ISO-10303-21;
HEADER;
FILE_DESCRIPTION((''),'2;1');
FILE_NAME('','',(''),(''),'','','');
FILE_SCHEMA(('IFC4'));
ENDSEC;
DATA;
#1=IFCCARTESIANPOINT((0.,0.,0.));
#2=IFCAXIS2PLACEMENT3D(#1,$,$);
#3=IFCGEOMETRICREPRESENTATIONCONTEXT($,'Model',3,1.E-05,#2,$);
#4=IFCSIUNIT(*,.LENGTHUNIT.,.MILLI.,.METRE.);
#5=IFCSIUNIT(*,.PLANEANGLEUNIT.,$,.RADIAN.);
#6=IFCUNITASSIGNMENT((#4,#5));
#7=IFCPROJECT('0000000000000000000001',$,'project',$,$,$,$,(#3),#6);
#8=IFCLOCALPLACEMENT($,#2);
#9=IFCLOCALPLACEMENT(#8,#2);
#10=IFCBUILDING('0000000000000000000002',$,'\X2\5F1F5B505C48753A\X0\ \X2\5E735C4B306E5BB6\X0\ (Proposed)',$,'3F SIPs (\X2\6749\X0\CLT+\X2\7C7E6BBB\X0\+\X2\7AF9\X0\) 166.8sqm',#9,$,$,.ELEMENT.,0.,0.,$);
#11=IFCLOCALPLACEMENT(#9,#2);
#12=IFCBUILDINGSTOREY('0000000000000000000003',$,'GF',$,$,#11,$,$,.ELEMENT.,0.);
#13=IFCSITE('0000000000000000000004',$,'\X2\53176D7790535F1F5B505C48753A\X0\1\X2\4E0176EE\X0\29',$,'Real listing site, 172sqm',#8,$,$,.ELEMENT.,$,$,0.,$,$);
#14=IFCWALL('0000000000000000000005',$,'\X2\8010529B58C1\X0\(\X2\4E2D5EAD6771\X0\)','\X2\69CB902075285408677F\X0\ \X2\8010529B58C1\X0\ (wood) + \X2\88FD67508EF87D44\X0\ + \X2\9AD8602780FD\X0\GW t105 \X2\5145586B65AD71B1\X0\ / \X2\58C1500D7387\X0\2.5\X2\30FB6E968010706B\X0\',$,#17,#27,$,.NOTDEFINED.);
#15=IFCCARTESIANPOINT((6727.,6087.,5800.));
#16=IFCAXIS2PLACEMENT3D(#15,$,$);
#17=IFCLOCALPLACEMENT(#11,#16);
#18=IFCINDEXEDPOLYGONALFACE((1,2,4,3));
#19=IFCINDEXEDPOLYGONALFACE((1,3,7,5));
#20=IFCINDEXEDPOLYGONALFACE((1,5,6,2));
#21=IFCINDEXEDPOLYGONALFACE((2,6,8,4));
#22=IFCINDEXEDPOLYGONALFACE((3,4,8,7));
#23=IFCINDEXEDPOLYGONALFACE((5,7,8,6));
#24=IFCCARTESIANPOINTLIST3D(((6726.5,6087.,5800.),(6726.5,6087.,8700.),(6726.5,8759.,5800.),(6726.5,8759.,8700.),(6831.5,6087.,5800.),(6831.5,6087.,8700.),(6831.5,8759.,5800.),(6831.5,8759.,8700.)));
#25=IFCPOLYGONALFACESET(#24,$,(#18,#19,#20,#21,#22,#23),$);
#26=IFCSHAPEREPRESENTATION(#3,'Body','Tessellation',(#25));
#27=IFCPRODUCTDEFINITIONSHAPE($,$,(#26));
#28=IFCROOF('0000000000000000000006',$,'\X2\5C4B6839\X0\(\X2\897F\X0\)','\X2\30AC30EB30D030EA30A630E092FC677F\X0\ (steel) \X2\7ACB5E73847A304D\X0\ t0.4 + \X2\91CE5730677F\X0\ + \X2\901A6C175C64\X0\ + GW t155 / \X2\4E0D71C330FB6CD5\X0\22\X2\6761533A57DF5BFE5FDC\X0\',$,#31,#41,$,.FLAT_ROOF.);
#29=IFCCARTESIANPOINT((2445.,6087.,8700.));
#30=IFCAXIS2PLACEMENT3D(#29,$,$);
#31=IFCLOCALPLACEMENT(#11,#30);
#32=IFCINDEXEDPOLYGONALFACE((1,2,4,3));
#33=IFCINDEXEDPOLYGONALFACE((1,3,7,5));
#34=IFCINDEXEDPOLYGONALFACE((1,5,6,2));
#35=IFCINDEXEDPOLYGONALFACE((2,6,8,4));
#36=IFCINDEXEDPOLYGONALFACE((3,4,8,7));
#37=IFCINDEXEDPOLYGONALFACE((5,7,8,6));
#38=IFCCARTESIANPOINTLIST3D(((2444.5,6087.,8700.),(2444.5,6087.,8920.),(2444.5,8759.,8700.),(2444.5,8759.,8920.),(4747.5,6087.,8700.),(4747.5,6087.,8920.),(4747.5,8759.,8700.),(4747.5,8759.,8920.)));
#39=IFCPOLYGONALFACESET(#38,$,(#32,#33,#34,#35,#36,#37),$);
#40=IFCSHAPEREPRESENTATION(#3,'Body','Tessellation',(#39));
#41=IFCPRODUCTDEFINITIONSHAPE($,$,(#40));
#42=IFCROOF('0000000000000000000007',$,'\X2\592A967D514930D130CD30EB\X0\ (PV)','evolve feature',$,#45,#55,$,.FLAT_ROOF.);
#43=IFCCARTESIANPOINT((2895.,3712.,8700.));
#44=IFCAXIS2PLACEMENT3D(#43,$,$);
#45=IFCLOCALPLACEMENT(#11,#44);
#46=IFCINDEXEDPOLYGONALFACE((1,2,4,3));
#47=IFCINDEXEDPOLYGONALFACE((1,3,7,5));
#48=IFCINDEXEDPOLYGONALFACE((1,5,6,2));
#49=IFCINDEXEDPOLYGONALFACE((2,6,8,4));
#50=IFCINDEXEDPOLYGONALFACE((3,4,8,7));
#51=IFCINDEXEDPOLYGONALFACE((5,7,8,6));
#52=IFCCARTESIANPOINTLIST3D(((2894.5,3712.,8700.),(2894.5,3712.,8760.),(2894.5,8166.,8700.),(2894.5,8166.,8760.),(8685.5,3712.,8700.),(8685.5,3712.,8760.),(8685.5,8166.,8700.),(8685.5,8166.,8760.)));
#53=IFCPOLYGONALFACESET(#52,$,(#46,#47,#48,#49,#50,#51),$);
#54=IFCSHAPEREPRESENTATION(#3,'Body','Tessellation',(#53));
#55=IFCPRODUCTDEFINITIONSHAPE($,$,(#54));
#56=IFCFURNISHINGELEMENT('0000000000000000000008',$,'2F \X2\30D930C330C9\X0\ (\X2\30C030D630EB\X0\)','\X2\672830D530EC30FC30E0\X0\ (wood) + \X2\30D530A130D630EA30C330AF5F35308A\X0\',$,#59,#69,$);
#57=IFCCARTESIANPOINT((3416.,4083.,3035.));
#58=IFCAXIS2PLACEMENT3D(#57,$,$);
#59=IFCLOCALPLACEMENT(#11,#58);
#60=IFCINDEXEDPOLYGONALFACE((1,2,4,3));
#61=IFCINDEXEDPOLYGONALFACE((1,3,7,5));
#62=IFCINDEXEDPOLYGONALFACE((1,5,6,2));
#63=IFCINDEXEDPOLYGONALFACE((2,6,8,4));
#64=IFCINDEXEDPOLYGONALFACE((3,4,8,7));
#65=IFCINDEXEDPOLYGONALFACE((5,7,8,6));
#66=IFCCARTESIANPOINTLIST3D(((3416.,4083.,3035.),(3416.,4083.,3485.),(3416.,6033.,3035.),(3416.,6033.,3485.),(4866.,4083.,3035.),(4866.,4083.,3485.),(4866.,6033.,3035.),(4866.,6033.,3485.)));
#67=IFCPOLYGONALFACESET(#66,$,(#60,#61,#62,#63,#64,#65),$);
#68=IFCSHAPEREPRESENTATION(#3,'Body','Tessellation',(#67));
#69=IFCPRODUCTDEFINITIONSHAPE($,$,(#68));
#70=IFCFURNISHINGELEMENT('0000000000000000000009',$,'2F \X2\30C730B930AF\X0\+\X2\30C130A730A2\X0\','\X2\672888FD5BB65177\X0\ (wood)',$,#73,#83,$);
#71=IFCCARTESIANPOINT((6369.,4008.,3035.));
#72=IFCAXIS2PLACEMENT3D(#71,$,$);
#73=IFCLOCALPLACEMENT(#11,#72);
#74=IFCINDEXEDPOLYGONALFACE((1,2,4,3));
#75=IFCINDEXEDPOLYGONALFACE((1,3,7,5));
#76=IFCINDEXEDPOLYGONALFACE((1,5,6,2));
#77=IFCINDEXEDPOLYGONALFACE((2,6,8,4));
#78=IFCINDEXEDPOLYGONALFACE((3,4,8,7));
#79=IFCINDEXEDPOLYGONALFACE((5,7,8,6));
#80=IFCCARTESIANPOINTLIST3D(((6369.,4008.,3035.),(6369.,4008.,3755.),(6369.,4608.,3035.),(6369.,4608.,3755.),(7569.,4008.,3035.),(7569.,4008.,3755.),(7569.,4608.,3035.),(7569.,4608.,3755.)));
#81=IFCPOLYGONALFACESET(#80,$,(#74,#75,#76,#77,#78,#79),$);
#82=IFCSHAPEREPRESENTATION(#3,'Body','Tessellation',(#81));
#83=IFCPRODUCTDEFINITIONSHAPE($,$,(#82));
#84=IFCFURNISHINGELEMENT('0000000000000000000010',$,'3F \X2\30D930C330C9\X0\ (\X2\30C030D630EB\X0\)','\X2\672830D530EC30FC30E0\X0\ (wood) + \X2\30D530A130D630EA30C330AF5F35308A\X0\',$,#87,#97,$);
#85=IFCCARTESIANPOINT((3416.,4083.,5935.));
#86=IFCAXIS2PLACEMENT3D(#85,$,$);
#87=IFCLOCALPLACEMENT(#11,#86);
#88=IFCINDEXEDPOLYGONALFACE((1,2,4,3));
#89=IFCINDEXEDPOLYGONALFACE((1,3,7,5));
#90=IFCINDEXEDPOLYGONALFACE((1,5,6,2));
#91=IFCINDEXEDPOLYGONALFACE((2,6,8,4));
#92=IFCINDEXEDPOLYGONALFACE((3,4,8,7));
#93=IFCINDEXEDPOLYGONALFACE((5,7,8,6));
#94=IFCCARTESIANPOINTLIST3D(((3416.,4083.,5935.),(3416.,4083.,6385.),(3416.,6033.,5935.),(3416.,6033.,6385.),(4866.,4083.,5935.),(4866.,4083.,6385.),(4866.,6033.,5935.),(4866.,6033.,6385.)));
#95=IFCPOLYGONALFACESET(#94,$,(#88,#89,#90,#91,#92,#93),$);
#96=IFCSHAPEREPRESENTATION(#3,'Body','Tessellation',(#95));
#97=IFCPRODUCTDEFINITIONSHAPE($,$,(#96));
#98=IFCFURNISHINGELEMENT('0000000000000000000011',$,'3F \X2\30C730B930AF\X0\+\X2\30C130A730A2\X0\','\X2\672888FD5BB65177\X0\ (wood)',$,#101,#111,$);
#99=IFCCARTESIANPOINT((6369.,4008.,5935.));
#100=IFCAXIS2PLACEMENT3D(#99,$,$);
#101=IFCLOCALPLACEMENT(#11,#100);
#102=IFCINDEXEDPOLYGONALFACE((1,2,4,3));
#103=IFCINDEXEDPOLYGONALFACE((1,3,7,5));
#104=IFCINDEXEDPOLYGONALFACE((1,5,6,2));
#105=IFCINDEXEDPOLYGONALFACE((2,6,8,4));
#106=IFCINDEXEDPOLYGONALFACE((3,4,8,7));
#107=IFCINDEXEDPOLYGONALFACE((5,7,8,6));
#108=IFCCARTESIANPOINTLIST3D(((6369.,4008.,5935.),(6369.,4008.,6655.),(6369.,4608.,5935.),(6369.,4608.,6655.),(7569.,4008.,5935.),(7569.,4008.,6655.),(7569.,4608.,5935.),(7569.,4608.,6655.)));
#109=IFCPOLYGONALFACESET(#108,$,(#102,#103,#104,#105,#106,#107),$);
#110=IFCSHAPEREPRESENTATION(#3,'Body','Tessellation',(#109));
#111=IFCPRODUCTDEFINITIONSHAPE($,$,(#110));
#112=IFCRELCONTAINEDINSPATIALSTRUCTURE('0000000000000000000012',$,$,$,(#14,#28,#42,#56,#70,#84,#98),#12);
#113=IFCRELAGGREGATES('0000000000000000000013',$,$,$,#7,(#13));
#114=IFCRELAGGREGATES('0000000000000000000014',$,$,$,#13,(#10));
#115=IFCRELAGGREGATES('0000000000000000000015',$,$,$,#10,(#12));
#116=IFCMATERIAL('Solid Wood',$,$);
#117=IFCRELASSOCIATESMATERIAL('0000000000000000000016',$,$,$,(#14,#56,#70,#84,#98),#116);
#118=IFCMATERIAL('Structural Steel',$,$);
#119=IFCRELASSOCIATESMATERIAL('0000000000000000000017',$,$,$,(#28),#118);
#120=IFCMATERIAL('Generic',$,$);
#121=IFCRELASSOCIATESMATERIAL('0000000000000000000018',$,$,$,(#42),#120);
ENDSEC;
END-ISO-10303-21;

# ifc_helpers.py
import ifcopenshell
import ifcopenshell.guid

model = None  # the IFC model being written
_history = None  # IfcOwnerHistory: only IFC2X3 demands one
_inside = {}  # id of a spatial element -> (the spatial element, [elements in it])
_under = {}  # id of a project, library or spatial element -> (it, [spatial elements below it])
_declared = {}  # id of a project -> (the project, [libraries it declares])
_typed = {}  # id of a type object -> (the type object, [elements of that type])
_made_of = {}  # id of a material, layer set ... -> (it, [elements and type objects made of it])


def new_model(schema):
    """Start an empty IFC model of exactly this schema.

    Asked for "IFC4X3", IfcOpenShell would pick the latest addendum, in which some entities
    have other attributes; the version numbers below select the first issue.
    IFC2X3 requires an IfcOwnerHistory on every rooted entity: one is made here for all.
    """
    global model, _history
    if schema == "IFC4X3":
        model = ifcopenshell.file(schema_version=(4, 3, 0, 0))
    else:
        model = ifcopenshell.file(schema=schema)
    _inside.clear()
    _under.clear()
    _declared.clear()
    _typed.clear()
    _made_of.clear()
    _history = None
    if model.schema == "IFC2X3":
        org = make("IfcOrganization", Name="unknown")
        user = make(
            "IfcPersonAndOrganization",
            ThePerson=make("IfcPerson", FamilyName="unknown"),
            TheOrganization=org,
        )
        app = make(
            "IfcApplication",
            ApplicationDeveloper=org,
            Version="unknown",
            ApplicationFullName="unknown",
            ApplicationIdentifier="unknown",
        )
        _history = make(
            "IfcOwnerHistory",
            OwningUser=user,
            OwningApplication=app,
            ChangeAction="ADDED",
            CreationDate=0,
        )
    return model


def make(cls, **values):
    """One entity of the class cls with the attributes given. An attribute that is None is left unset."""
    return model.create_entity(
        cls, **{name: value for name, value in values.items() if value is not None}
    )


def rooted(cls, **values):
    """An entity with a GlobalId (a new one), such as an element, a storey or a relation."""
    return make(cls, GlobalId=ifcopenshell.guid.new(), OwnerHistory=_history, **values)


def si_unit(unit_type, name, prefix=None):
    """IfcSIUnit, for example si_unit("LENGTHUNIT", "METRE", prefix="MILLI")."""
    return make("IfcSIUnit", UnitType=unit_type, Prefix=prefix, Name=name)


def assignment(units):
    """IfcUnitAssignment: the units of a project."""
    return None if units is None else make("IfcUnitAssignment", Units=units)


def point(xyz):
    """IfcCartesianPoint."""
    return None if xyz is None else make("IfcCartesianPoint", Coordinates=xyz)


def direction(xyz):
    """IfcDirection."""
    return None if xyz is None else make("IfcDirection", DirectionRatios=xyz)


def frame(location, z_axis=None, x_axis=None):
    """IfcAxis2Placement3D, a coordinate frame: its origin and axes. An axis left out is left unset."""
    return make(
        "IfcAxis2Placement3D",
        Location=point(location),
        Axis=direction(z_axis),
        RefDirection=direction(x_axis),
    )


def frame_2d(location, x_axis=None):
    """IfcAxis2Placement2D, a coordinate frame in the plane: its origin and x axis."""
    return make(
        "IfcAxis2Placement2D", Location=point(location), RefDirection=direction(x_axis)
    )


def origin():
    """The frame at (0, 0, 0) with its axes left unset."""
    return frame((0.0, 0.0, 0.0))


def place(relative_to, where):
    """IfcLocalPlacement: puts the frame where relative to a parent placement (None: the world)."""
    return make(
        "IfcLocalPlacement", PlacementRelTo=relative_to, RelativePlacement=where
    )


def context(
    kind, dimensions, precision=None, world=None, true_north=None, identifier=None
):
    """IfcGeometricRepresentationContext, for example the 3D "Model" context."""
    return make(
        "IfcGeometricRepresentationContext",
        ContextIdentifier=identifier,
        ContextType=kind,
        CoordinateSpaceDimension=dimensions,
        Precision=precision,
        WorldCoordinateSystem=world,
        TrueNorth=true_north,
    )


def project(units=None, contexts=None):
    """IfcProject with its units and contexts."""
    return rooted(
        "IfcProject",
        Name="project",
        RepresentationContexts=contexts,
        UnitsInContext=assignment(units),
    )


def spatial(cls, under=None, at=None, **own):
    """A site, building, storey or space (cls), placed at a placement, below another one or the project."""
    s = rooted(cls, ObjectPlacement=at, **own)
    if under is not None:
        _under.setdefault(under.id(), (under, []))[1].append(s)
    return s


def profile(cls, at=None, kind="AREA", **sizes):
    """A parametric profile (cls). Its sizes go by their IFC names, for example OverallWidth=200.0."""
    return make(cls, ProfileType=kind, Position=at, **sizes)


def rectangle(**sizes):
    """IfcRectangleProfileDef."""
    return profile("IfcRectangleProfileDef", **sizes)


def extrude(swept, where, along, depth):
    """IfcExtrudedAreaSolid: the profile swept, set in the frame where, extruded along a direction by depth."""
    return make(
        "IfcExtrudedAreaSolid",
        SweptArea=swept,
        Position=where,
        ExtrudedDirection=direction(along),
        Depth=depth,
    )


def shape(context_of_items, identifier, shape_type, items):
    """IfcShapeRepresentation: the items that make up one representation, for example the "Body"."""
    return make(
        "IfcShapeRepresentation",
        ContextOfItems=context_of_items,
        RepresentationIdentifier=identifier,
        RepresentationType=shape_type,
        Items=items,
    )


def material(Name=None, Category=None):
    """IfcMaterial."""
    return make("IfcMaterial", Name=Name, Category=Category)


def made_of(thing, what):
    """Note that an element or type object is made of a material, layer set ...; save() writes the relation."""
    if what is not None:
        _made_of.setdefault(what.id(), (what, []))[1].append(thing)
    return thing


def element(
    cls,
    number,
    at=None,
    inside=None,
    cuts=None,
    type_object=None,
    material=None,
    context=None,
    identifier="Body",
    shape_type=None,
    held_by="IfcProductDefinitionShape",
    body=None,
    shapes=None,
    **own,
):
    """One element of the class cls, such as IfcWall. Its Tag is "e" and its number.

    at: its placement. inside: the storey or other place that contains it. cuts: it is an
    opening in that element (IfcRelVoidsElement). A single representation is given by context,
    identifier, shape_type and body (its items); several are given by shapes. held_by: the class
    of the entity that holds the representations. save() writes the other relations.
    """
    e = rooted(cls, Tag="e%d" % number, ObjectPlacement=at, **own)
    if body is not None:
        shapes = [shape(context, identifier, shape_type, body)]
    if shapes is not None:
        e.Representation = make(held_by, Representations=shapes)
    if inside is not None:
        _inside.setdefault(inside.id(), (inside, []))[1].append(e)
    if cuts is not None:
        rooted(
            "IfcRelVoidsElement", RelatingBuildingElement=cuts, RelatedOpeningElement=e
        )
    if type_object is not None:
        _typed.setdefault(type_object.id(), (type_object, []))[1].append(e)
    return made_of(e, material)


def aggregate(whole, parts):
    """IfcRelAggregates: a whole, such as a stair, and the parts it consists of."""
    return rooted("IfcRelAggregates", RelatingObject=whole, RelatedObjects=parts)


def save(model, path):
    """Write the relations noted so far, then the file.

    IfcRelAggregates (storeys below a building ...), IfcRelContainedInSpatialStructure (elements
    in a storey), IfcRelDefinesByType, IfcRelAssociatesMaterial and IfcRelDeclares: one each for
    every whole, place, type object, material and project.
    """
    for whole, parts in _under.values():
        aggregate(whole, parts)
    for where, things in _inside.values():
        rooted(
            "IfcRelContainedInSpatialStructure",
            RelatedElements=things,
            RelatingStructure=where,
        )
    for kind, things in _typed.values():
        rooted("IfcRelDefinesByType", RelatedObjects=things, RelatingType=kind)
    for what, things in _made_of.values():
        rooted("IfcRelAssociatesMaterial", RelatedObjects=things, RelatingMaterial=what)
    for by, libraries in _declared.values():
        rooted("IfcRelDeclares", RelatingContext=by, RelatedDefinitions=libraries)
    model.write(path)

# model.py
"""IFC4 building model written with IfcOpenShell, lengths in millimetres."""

from ifc_helpers import new_model, si_unit, frame, frame_2d, origin, place, context, project, spatial, rectangle, extrude, material, element, save


model = new_model("IFC4")

# Units and contexts
model_context = context("Model", 3, precision=1e-05, world=origin())
ifc_project = project(units=[si_unit("LENGTHUNIT", "METRE", prefix="MILLI"), si_unit("PLANEANGLEUNIT", "RADIAN")], contexts=[model_context])

# Site, building, storey
site_placement = place(None, origin())
site = spatial("IfcSite", under=ifc_project, at=site_placement, Name="北海道弟子屈町1丁目29", ObjectType="Real listing site, 172sqm", CompositionType="ELEMENT", RefElevation=0.0)
building_placement = place(site_placement, origin())
building = spatial("IfcBuilding", under=site, at=building_placement, Name="弟子屈町 平屋の家 (Proposed)", ObjectType="3F SIPs (杉CLT+籾殻+竹) 166.8sqm", CompositionType="ELEMENT", ElevationOfRefHeight=0.0, ElevationOfTerrain=0.0)
storey_placement = place(building_placement, origin())
storey = spatial("IfcBuildingStorey", under=building, at=storey_placement, Name="GF", CompositionType="ELEMENT", Elevation=0.0)

# Shared definitions
ifc_material_1 = material(Name="Solid Wood")

# Wall
wall_1_placement = place(storey_placement, frame((6727.0, 6087.0, 5800.0)))
element("IfcWall", 1, at=wall_1_placement, inside=storey, material=ifc_material_1, Name="耐力壁(中庭東)", Description="構造用合板 耐力壁 (wood) + 製材軸組 + 高性能GW t105 充填断熱 / 壁倍率2.5・準耐火", PredefinedType="NOTDEFINED", context=model_context, shape_type="SweptSolid", body=[
    extrude(rectangle(XDim=105.0, YDim=2672.0, at=frame_2d((52.0, 1336.0))), frame((6727.0, 6087.0, 5800.0)), (0.0, 0.0, 1.0), 2900.0),
])

# Roofs
ifc_material_2 = material(Name="Structural Steel")
roof_1_placement = place(storey_placement, frame((2445.0, 6087.0, 8700.0)))
element("IfcRoof", 2, at=roof_1_placement, inside=storey, material=ifc_material_2, Name="屋根(西)", Description="ガルバリウム鋼板 (steel) 立平葺き t0.4 + 野地板 + 通気層 + GW t155 / 不燃・法22条区域対応", PredefinedType="FLAT_ROOF", context=model_context, shape_type="SweptSolid", body=[
    extrude(rectangle(XDim=2303.0, YDim=2672.0, at=frame_2d((1151.0, 1336.0))), frame((2445.0, 6087.0, 8700.0)), (0.0, 0.0, 1.0), 220.0),
])
ifc_material_3 = material(Name="Generic")
roof_2_placement = place(storey_placement, frame((2895.0, 3712.0, 8700.0)))
element("IfcRoof", 3, at=roof_2_placement, inside=storey, material=ifc_material_3, Name="太陽光パネル (PV)", Description="evolve feature", PredefinedType="FLAT_ROOF", context=model_context, shape_type="SweptSolid", body=[
    extrude(rectangle(XDim=5791.0, YDim=4454.0, at=frame_2d((2895.0, 2227.0))), frame((2895.0, 3712.0, 8700.0)), (0.0, 0.0, 1.0), 60.0),
])

# Furnishing elements
furnishing_1_placement = place(storey_placement, frame((3416.0, 4083.0, 3035.0)))
element("IfcFurnishingElement", 4, at=furnishing_1_placement, inside=storey, material=ifc_material_1, Name="2F ベッド (ダブル)", Description="木フレーム (wood) + ファブリック張り", context=model_context, shape_type="SweptSolid", body=[
    extrude(rectangle(XDim=1450.0, YDim=1950.0, at=frame_2d((725.0, 975.0))), frame((3416.0, 4083.0, 3035.0)), (0.0, 0.0, 1.0), 450.0),
])
furnishing_2_placement = place(storey_placement, frame((6369.0, 4008.0, 3035.0)))
element("IfcFurnishingElement", 5, at=furnishing_2_placement, inside=storey, material=ifc_material_1, Name="2F デスク+チェア", Description="木製家具 (wood)", context=model_context, shape_type="SweptSolid", body=[
    extrude(rectangle(XDim=1200.0, YDim=600.0, at=frame_2d((600.0, 300.0))), frame((6369.0, 4008.0, 3035.0)), (0.0, 0.0, 1.0), 720.0),
])
furnishing_3_placement = place(storey_placement, frame((3416.0, 4083.0, 5935.0)))
element("IfcFurnishingElement", 6, at=furnishing_3_placement, inside=storey, material=ifc_material_1, Name="3F ベッド (ダブル)", Description="木フレーム (wood) + ファブリック張り", context=model_context, shape_type="SweptSolid", body=[
    extrude(rectangle(XDim=1450.0, YDim=1950.0, at=frame_2d((725.0, 975.0))), frame((3416.0, 4083.0, 5935.0)), (0.0, 0.0, 1.0), 450.0),
])
furnishing_4_placement = place(storey_placement, frame((6369.0, 4008.0, 5935.0)))
element("IfcFurnishingElement", 7, at=furnishing_4_placement, inside=storey, material=ifc_material_1, Name="3F デスク+チェア", Description="木製家具 (wood)", context=model_context, shape_type="SweptSolid", body=[
    extrude(rectangle(XDim=1200.0, YDim=600.0, at=frame_2d((600.0, 300.0))), frame((6369.0, 4008.0, 5935.0)), (0.0, 0.0, 1.0), 720.0),
])

save(model, "model.ifc")
